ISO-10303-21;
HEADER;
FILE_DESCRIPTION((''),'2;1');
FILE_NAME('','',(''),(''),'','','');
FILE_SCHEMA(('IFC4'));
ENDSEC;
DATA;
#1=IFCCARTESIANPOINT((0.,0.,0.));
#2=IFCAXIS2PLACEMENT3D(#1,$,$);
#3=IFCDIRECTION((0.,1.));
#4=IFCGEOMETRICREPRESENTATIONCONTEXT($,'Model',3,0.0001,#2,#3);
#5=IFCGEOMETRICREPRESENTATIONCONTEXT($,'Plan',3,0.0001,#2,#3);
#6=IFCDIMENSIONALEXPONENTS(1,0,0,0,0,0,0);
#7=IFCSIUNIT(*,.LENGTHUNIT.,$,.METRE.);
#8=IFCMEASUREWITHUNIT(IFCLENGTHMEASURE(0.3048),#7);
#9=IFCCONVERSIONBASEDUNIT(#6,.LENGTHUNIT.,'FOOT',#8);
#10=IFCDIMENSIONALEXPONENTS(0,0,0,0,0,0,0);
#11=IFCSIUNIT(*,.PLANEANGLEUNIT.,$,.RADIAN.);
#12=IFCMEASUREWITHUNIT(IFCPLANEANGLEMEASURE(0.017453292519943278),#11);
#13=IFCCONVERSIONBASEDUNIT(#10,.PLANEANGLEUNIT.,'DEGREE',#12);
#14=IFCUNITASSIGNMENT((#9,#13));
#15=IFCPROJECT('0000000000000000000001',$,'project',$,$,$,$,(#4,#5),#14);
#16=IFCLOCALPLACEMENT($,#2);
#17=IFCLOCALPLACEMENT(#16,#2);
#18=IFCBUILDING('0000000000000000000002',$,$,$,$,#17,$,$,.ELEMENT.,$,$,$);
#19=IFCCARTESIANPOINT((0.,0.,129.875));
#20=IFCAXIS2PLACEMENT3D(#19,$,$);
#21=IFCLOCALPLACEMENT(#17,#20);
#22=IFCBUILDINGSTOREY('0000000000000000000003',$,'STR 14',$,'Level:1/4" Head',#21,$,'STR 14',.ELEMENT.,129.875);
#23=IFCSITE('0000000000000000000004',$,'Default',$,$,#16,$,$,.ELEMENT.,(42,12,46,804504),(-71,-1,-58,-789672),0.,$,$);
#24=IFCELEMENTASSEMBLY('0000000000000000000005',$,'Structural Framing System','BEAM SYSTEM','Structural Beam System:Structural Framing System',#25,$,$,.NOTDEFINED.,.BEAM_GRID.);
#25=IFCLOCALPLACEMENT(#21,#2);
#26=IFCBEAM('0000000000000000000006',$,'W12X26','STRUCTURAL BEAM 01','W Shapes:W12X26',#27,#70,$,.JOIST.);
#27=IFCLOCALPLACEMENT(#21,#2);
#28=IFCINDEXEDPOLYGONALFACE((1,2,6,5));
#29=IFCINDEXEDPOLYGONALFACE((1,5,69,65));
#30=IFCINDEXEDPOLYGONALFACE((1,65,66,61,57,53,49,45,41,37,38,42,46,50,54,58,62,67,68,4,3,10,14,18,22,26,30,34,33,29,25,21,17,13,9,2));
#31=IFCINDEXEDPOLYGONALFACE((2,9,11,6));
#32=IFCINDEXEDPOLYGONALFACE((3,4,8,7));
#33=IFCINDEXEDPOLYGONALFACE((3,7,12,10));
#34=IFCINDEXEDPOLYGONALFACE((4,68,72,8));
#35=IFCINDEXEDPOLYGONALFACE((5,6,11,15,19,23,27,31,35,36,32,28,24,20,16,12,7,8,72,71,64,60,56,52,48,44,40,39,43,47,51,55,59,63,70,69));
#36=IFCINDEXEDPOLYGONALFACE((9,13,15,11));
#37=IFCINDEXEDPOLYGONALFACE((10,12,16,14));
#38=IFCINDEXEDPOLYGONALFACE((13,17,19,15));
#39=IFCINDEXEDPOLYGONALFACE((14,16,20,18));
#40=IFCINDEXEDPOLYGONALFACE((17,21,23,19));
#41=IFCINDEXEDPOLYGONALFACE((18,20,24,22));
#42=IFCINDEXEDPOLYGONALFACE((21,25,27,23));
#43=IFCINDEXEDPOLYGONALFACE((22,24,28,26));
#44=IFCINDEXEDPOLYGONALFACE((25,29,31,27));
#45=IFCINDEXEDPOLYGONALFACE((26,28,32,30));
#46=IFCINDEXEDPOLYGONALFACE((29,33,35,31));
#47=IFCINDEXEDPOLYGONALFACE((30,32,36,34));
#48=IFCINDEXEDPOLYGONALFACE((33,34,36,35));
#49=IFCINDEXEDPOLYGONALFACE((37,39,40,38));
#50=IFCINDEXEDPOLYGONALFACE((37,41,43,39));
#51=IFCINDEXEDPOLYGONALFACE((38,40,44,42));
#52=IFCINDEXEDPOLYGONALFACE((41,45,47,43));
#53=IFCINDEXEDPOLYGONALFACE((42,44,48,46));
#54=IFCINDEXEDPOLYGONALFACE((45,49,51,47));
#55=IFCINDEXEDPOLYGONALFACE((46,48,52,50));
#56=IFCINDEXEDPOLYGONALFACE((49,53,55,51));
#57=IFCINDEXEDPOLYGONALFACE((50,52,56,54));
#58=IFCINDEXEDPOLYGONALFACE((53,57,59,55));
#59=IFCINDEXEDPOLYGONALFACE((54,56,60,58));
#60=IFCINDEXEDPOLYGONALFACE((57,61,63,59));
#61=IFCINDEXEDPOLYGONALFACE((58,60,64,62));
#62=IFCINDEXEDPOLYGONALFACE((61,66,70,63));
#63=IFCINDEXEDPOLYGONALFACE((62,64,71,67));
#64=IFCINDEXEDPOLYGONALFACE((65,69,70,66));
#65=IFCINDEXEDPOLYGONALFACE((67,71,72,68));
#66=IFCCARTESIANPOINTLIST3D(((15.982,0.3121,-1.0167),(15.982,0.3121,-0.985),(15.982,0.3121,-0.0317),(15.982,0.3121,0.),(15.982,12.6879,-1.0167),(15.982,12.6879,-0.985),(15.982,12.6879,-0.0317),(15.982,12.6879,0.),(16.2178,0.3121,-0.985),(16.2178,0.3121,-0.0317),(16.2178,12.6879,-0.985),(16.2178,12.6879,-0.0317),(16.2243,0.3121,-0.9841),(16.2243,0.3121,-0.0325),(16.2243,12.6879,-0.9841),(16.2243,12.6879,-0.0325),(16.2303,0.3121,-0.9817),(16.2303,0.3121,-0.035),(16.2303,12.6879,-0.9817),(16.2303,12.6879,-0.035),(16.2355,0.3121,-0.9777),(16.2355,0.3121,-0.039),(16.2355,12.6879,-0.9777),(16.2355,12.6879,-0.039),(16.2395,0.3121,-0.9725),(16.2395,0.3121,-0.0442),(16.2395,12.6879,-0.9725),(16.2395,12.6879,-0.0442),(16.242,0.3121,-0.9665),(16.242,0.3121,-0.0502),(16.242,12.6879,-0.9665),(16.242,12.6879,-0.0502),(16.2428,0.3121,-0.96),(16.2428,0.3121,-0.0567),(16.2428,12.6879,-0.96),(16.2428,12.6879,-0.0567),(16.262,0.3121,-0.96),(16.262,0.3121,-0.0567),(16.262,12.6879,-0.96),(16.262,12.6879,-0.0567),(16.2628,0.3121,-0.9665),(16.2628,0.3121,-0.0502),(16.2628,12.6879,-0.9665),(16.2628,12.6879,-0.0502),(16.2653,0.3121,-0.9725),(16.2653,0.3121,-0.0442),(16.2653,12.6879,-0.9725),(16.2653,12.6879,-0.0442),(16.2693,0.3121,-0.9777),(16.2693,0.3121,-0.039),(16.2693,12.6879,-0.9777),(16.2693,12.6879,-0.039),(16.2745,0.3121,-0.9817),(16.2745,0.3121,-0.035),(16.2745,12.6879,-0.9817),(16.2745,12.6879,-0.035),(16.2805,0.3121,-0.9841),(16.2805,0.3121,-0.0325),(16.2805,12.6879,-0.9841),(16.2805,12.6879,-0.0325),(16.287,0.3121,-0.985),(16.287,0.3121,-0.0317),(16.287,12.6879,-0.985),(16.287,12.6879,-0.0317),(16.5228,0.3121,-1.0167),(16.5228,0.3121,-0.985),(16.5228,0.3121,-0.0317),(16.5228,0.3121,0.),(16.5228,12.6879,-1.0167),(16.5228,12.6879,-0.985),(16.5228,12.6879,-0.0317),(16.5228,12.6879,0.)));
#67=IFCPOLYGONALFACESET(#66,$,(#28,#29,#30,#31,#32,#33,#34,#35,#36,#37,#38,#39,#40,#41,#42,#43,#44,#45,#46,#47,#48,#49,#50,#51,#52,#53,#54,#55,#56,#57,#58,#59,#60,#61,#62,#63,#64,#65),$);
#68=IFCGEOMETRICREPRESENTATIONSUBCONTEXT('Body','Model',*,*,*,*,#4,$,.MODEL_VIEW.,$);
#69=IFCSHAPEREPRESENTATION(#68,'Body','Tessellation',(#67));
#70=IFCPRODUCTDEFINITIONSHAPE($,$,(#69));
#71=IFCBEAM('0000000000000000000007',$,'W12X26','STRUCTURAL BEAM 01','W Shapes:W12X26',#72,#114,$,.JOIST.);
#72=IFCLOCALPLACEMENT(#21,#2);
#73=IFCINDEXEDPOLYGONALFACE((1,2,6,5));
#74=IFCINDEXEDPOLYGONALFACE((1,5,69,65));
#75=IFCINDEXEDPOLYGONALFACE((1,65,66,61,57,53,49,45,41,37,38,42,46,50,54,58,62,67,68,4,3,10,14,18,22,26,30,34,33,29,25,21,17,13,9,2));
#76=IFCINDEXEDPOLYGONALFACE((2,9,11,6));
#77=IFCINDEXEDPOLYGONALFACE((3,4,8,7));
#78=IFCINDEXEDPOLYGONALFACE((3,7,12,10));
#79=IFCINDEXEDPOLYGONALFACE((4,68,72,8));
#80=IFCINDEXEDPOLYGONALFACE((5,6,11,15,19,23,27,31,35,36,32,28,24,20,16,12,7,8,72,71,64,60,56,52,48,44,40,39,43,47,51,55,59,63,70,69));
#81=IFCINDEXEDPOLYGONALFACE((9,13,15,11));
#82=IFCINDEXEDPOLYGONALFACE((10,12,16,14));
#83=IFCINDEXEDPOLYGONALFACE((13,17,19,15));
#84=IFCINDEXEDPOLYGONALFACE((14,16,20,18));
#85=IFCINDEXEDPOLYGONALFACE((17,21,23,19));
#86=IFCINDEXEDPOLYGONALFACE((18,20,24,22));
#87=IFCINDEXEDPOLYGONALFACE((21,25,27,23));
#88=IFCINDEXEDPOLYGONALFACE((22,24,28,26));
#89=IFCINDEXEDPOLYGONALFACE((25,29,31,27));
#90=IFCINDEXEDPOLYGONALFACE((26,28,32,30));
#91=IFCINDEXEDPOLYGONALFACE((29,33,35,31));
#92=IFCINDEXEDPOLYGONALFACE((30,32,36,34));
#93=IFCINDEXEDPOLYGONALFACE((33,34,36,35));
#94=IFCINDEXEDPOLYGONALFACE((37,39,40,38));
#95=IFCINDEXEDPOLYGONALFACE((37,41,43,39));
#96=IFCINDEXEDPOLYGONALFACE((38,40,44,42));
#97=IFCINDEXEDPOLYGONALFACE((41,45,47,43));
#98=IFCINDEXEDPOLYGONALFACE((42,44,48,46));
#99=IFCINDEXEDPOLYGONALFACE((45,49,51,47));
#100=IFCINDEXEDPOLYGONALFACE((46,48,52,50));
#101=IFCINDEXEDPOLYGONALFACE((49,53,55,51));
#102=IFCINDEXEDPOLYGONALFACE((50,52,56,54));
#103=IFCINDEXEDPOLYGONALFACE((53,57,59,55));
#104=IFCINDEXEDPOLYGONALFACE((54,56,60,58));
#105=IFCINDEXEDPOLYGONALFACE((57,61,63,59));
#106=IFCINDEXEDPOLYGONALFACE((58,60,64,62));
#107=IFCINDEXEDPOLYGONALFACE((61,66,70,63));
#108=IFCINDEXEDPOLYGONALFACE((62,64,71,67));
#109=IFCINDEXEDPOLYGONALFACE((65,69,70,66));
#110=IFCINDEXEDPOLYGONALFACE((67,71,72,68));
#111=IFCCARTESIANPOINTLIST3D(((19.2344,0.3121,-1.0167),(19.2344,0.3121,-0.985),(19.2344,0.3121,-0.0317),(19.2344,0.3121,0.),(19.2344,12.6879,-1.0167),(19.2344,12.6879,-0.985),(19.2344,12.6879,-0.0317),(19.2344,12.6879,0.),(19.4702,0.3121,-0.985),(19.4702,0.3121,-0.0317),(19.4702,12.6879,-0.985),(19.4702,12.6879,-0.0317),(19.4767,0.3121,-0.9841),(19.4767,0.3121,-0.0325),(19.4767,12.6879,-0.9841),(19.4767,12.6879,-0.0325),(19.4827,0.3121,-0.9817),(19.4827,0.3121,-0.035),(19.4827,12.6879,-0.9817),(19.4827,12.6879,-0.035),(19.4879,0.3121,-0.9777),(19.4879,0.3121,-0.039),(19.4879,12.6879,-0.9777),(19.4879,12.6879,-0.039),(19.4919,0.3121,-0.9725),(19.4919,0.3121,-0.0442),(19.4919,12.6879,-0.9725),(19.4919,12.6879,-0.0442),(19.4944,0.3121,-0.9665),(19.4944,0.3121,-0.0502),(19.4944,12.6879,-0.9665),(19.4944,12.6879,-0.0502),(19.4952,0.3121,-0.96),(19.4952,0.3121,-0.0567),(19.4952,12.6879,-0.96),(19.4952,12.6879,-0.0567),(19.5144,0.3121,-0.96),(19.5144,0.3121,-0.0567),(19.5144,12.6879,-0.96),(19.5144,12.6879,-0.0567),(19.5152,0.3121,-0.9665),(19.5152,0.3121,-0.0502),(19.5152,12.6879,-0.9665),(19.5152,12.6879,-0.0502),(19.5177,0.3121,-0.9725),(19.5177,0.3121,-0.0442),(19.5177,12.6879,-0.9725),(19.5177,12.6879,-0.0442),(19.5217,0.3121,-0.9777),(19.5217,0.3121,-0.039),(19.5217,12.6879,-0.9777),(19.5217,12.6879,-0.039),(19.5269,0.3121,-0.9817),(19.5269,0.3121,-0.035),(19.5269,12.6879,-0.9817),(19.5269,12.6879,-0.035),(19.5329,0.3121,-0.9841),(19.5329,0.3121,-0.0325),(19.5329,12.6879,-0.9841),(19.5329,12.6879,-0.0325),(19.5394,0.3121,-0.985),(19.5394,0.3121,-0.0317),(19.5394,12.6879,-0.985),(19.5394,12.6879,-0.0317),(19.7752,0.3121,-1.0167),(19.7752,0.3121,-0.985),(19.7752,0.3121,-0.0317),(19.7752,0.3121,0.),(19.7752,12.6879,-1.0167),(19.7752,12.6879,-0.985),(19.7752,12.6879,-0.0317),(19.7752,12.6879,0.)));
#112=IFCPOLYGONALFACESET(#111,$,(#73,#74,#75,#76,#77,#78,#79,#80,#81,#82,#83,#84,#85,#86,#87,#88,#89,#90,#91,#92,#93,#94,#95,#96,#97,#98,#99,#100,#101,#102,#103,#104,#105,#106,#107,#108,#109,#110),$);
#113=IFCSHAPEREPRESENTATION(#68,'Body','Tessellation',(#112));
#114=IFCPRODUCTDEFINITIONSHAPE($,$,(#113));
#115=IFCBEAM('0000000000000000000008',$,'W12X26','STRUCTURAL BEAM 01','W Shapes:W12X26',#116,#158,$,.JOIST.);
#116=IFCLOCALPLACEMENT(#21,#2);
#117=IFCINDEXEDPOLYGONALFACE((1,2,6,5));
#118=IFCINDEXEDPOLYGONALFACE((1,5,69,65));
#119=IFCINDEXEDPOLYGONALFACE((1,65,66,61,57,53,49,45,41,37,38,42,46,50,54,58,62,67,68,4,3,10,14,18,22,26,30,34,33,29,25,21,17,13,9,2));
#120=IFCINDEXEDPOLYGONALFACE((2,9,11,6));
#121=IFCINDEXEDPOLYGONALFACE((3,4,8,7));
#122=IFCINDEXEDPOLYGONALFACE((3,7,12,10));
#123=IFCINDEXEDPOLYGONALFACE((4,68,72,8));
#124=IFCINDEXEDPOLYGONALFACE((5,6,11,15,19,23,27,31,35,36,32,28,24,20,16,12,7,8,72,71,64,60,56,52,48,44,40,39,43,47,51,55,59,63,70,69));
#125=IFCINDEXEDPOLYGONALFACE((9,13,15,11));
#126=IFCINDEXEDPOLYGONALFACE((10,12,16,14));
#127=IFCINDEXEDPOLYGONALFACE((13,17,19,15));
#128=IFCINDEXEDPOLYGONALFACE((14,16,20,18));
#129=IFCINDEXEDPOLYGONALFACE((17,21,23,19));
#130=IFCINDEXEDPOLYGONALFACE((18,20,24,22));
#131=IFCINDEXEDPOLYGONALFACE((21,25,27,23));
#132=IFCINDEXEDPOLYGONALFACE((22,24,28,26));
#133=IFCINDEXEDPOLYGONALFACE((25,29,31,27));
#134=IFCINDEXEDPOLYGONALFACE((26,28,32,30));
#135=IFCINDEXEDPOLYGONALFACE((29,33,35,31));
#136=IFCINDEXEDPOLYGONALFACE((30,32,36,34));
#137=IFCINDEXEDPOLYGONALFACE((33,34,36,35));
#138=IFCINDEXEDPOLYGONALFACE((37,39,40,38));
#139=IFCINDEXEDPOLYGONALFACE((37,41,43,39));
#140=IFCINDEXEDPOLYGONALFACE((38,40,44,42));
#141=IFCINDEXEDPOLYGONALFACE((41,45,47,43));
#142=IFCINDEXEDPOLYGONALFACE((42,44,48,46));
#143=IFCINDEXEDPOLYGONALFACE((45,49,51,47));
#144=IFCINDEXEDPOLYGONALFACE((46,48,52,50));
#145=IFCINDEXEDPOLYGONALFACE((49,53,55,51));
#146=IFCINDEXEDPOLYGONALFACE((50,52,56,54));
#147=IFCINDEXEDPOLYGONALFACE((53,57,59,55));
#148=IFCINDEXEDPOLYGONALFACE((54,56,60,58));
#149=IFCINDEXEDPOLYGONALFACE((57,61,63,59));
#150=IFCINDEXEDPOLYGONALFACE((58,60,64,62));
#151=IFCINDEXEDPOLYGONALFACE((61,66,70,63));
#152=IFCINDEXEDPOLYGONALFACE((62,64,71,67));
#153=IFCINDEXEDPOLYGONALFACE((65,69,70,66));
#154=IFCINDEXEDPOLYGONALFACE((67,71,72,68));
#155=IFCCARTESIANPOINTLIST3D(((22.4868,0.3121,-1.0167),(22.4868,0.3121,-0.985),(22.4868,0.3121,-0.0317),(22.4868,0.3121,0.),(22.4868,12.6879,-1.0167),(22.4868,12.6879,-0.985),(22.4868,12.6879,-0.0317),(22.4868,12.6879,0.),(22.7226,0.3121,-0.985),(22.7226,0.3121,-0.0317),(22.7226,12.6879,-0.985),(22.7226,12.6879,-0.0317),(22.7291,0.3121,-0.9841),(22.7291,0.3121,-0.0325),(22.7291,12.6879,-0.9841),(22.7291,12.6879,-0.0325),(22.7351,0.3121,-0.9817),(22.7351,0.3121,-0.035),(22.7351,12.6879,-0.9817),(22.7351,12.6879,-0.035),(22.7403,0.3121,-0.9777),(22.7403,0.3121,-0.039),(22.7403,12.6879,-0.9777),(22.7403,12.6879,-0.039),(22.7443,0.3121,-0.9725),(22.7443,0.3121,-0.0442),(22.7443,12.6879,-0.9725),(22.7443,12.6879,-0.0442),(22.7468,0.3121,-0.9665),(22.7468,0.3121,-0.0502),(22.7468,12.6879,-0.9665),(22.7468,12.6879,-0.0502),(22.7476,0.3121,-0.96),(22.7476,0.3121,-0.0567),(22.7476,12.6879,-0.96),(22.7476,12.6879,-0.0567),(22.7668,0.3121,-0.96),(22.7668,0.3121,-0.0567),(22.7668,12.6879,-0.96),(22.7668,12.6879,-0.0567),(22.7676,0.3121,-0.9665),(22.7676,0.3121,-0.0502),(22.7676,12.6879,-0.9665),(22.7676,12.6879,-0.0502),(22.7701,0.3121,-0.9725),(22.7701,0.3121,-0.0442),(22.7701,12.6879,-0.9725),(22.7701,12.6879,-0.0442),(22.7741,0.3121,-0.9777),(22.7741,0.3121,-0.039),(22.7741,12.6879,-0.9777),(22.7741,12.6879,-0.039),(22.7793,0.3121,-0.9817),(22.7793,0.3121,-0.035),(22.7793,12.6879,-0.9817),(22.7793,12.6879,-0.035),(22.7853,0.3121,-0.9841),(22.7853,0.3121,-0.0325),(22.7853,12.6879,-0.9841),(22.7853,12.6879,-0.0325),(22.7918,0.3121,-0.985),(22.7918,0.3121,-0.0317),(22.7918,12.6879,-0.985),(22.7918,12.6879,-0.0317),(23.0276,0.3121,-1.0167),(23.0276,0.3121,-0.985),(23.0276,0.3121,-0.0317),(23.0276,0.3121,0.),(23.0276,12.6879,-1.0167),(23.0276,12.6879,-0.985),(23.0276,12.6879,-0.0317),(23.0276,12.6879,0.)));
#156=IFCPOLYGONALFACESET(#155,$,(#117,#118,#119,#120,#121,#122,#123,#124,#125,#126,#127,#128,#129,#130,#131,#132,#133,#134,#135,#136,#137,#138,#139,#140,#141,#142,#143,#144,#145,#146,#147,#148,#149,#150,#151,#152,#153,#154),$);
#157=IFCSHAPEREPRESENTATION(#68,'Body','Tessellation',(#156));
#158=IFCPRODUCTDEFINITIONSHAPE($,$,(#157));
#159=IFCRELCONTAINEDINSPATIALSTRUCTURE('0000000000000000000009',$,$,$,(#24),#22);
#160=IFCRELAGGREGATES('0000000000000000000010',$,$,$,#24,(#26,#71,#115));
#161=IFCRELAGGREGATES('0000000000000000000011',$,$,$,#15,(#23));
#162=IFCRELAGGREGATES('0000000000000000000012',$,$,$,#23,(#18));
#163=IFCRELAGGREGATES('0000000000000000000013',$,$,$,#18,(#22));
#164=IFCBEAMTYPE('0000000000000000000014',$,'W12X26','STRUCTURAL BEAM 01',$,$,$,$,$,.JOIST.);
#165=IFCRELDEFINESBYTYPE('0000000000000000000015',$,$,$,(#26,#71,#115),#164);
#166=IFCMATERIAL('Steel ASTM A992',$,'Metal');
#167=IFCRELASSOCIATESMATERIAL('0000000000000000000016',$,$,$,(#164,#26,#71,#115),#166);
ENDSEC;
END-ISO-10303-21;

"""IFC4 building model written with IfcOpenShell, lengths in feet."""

from ifc_helpers import new_model, entity, si_unit, converted_unit, direction, frame, origin, place, context, subcontext, project, spatial, line, arc, indexed_curve, outline, extrude, source, transform, mapped, material, type_object, type_shapes, element, aggregate, save


model = new_model("IFC4")

# Units and contexts
model_context = context("Model", 3, precision=0.0001, world=origin(), true_north=direction((0.0, 1.0)))
plan_context = context("Plan", 3, precision=0.0001, world=origin(), true_north=direction((0.0, 1.0)))
body_context = subcontext(model_context, "Body", "Model", "MODEL_VIEW")
ifc_project = project(units=[converted_unit("LENGTHUNIT", "FOOT", entity("IfcLengthMeasure", 0.3048), si_unit("LENGTHUNIT", "METRE"), dimensions=[1, 0, 0, 0, 0, 0, 0]), converted_unit("PLANEANGLEUNIT", "DEGREE", entity("IfcPlaneAngleMeasure", 0.017453292519943278), si_unit("PLANEANGLEUNIT", "RADIAN"), dimensions=[0, 0, 0, 0, 0, 0, 0])], contexts=[model_context, plan_context])

# Site, building, storey
site_placement = place(None, origin())
site = spatial("IfcSite", under=ifc_project, at=site_placement, Name="Default", CompositionType="ELEMENT", RefLatitude=(42, 12, 46, 804504), RefLongitude=(-71, -1, -58, -789672), RefElevation=0.0)
building_placement = place(site_placement, origin())
building = spatial("IfcBuilding", under=site, at=building_placement, CompositionType="ELEMENT")
storey_placement = place(building_placement, frame((0.0, 0.0, 129.875)))
storey = spatial("IfcBuildingStorey", under=building, at=storey_placement, Name="STR 14", ObjectType="Level:1/4\" Head", LongName="STR 14", CompositionType="ELEMENT", Elevation=129.875)

# Shared definitions
ifc_material = material(Name="Steel ASTM A992", Category="Metal")

# Element assembly, beams
beam_type_1 = type_object("IfcBeamType", Name="W12X26", Description="STRUCTURAL BEAM 01", PredefinedType="JOIST", material=ifc_material)
shared_shape_1 = source(origin(), body_context, "Body", "SweptSolid", [
    extrude(outline(indexed_curve([(-0.2704, -0.4767), (-0.2704, -0.5083), (0.2704, -0.5083), (0.2704, -0.4767), (0.0346, -0.4767), (0.0169, -0.4693), (0.0096, -0.4517), (0.0096, 0.4517), (0.0169, 0.4693), (0.0346, 0.4767), (0.2704, 0.4767), (0.2704, 0.5083), (-0.2704, 0.5083), (-0.2704, 0.4767), (-0.0346, 0.4767), (-0.0169, 0.4693), (-0.0096, 0.4517), (-0.0096, -0.4517), (-0.0169, -0.4693), (-0.0346, -0.4767)], segments=[line(1, 2, 3, 4, 5), arc(5, 6, 7), line(7, 8), arc(8, 9, 10), line(10, 11, 12, 13, 14, 15), arc(15, 16, 17), line(17, 18), arc(18, 19, 20), line(20, 1)], self_intersect=False)), frame((-6.1879, 0.0, 0.0), z_axis=(-1.0, 0.0, 0.0), x_axis=(0.0, -1.0, 0.0)), (0.0, 0.0, -1.0), 12.3758),
])
type_shapes(beam_type_1, [shared_shape_1])
assembly_1_placement = place(storey_placement, origin())
assembly_1 = element("IfcElementAssembly", 1, at=assembly_1_placement, inside=storey, Name="Structural Framing System", Description="BEAM SYSTEM", ObjectType="Structural Beam System:Structural Framing System", AssemblyPlace="NOTDEFINED", PredefinedType="BEAM_GRID")
beam_1_placement = place(assembly_1_placement, frame((16.2524, 6.5, -0.5083), z_axis=(0.0, 0.0, 1.0), x_axis=(0.0, 1.0, 0.0)))
beam_1 = element("IfcBeam", 2, at=beam_1_placement, type_object=beam_type_1, material=ifc_material, Name="W12X26", Description="STRUCTURAL BEAM 01", ObjectType="W Shapes:W12X26", PredefinedType="JOIST", context=body_context, shape_type="MappedRepresentation", body=[
    mapped(shared_shape_1, transform((0.0, 0.0, 0.0), scale=1.0)),
])
beam_2_placement = place(assembly_1_placement, frame((19.5048, 6.5, -0.5083), z_axis=(0.0, 0.0, 1.0), x_axis=(0.0, 1.0, 0.0)))
beam_2 = element("IfcBeam", 3, at=beam_2_placement, type_object=beam_type_1, material=ifc_material, Name="W12X26", Description="STRUCTURAL BEAM 01", ObjectType="W Shapes:W12X26", PredefinedType="JOIST", context=body_context, shape_type="MappedRepresentation", body=[
    mapped(shared_shape_1, transform((0.0, 0.0, 0.0), scale=1.0)),
])
beam_3_placement = place(assembly_1_placement, frame((22.7572, 6.5, -0.5083), z_axis=(0.0, 0.0, 1.0), x_axis=(0.0, 1.0, 0.0)))
beam_3 = element("IfcBeam", 4, at=beam_3_placement, type_object=beam_type_1, material=ifc_material, Name="W12X26", Description="STRUCTURAL BEAM 01", ObjectType="W Shapes:W12X26", PredefinedType="JOIST", context=body_context, shape_type="MappedRepresentation", body=[
    mapped(shared_shape_1, transform((0.0, 0.0, 0.0), scale=1.0)),
])
aggregate(assembly_1, [beam_1, beam_2, beam_3])

save(model, "model.ifc")
